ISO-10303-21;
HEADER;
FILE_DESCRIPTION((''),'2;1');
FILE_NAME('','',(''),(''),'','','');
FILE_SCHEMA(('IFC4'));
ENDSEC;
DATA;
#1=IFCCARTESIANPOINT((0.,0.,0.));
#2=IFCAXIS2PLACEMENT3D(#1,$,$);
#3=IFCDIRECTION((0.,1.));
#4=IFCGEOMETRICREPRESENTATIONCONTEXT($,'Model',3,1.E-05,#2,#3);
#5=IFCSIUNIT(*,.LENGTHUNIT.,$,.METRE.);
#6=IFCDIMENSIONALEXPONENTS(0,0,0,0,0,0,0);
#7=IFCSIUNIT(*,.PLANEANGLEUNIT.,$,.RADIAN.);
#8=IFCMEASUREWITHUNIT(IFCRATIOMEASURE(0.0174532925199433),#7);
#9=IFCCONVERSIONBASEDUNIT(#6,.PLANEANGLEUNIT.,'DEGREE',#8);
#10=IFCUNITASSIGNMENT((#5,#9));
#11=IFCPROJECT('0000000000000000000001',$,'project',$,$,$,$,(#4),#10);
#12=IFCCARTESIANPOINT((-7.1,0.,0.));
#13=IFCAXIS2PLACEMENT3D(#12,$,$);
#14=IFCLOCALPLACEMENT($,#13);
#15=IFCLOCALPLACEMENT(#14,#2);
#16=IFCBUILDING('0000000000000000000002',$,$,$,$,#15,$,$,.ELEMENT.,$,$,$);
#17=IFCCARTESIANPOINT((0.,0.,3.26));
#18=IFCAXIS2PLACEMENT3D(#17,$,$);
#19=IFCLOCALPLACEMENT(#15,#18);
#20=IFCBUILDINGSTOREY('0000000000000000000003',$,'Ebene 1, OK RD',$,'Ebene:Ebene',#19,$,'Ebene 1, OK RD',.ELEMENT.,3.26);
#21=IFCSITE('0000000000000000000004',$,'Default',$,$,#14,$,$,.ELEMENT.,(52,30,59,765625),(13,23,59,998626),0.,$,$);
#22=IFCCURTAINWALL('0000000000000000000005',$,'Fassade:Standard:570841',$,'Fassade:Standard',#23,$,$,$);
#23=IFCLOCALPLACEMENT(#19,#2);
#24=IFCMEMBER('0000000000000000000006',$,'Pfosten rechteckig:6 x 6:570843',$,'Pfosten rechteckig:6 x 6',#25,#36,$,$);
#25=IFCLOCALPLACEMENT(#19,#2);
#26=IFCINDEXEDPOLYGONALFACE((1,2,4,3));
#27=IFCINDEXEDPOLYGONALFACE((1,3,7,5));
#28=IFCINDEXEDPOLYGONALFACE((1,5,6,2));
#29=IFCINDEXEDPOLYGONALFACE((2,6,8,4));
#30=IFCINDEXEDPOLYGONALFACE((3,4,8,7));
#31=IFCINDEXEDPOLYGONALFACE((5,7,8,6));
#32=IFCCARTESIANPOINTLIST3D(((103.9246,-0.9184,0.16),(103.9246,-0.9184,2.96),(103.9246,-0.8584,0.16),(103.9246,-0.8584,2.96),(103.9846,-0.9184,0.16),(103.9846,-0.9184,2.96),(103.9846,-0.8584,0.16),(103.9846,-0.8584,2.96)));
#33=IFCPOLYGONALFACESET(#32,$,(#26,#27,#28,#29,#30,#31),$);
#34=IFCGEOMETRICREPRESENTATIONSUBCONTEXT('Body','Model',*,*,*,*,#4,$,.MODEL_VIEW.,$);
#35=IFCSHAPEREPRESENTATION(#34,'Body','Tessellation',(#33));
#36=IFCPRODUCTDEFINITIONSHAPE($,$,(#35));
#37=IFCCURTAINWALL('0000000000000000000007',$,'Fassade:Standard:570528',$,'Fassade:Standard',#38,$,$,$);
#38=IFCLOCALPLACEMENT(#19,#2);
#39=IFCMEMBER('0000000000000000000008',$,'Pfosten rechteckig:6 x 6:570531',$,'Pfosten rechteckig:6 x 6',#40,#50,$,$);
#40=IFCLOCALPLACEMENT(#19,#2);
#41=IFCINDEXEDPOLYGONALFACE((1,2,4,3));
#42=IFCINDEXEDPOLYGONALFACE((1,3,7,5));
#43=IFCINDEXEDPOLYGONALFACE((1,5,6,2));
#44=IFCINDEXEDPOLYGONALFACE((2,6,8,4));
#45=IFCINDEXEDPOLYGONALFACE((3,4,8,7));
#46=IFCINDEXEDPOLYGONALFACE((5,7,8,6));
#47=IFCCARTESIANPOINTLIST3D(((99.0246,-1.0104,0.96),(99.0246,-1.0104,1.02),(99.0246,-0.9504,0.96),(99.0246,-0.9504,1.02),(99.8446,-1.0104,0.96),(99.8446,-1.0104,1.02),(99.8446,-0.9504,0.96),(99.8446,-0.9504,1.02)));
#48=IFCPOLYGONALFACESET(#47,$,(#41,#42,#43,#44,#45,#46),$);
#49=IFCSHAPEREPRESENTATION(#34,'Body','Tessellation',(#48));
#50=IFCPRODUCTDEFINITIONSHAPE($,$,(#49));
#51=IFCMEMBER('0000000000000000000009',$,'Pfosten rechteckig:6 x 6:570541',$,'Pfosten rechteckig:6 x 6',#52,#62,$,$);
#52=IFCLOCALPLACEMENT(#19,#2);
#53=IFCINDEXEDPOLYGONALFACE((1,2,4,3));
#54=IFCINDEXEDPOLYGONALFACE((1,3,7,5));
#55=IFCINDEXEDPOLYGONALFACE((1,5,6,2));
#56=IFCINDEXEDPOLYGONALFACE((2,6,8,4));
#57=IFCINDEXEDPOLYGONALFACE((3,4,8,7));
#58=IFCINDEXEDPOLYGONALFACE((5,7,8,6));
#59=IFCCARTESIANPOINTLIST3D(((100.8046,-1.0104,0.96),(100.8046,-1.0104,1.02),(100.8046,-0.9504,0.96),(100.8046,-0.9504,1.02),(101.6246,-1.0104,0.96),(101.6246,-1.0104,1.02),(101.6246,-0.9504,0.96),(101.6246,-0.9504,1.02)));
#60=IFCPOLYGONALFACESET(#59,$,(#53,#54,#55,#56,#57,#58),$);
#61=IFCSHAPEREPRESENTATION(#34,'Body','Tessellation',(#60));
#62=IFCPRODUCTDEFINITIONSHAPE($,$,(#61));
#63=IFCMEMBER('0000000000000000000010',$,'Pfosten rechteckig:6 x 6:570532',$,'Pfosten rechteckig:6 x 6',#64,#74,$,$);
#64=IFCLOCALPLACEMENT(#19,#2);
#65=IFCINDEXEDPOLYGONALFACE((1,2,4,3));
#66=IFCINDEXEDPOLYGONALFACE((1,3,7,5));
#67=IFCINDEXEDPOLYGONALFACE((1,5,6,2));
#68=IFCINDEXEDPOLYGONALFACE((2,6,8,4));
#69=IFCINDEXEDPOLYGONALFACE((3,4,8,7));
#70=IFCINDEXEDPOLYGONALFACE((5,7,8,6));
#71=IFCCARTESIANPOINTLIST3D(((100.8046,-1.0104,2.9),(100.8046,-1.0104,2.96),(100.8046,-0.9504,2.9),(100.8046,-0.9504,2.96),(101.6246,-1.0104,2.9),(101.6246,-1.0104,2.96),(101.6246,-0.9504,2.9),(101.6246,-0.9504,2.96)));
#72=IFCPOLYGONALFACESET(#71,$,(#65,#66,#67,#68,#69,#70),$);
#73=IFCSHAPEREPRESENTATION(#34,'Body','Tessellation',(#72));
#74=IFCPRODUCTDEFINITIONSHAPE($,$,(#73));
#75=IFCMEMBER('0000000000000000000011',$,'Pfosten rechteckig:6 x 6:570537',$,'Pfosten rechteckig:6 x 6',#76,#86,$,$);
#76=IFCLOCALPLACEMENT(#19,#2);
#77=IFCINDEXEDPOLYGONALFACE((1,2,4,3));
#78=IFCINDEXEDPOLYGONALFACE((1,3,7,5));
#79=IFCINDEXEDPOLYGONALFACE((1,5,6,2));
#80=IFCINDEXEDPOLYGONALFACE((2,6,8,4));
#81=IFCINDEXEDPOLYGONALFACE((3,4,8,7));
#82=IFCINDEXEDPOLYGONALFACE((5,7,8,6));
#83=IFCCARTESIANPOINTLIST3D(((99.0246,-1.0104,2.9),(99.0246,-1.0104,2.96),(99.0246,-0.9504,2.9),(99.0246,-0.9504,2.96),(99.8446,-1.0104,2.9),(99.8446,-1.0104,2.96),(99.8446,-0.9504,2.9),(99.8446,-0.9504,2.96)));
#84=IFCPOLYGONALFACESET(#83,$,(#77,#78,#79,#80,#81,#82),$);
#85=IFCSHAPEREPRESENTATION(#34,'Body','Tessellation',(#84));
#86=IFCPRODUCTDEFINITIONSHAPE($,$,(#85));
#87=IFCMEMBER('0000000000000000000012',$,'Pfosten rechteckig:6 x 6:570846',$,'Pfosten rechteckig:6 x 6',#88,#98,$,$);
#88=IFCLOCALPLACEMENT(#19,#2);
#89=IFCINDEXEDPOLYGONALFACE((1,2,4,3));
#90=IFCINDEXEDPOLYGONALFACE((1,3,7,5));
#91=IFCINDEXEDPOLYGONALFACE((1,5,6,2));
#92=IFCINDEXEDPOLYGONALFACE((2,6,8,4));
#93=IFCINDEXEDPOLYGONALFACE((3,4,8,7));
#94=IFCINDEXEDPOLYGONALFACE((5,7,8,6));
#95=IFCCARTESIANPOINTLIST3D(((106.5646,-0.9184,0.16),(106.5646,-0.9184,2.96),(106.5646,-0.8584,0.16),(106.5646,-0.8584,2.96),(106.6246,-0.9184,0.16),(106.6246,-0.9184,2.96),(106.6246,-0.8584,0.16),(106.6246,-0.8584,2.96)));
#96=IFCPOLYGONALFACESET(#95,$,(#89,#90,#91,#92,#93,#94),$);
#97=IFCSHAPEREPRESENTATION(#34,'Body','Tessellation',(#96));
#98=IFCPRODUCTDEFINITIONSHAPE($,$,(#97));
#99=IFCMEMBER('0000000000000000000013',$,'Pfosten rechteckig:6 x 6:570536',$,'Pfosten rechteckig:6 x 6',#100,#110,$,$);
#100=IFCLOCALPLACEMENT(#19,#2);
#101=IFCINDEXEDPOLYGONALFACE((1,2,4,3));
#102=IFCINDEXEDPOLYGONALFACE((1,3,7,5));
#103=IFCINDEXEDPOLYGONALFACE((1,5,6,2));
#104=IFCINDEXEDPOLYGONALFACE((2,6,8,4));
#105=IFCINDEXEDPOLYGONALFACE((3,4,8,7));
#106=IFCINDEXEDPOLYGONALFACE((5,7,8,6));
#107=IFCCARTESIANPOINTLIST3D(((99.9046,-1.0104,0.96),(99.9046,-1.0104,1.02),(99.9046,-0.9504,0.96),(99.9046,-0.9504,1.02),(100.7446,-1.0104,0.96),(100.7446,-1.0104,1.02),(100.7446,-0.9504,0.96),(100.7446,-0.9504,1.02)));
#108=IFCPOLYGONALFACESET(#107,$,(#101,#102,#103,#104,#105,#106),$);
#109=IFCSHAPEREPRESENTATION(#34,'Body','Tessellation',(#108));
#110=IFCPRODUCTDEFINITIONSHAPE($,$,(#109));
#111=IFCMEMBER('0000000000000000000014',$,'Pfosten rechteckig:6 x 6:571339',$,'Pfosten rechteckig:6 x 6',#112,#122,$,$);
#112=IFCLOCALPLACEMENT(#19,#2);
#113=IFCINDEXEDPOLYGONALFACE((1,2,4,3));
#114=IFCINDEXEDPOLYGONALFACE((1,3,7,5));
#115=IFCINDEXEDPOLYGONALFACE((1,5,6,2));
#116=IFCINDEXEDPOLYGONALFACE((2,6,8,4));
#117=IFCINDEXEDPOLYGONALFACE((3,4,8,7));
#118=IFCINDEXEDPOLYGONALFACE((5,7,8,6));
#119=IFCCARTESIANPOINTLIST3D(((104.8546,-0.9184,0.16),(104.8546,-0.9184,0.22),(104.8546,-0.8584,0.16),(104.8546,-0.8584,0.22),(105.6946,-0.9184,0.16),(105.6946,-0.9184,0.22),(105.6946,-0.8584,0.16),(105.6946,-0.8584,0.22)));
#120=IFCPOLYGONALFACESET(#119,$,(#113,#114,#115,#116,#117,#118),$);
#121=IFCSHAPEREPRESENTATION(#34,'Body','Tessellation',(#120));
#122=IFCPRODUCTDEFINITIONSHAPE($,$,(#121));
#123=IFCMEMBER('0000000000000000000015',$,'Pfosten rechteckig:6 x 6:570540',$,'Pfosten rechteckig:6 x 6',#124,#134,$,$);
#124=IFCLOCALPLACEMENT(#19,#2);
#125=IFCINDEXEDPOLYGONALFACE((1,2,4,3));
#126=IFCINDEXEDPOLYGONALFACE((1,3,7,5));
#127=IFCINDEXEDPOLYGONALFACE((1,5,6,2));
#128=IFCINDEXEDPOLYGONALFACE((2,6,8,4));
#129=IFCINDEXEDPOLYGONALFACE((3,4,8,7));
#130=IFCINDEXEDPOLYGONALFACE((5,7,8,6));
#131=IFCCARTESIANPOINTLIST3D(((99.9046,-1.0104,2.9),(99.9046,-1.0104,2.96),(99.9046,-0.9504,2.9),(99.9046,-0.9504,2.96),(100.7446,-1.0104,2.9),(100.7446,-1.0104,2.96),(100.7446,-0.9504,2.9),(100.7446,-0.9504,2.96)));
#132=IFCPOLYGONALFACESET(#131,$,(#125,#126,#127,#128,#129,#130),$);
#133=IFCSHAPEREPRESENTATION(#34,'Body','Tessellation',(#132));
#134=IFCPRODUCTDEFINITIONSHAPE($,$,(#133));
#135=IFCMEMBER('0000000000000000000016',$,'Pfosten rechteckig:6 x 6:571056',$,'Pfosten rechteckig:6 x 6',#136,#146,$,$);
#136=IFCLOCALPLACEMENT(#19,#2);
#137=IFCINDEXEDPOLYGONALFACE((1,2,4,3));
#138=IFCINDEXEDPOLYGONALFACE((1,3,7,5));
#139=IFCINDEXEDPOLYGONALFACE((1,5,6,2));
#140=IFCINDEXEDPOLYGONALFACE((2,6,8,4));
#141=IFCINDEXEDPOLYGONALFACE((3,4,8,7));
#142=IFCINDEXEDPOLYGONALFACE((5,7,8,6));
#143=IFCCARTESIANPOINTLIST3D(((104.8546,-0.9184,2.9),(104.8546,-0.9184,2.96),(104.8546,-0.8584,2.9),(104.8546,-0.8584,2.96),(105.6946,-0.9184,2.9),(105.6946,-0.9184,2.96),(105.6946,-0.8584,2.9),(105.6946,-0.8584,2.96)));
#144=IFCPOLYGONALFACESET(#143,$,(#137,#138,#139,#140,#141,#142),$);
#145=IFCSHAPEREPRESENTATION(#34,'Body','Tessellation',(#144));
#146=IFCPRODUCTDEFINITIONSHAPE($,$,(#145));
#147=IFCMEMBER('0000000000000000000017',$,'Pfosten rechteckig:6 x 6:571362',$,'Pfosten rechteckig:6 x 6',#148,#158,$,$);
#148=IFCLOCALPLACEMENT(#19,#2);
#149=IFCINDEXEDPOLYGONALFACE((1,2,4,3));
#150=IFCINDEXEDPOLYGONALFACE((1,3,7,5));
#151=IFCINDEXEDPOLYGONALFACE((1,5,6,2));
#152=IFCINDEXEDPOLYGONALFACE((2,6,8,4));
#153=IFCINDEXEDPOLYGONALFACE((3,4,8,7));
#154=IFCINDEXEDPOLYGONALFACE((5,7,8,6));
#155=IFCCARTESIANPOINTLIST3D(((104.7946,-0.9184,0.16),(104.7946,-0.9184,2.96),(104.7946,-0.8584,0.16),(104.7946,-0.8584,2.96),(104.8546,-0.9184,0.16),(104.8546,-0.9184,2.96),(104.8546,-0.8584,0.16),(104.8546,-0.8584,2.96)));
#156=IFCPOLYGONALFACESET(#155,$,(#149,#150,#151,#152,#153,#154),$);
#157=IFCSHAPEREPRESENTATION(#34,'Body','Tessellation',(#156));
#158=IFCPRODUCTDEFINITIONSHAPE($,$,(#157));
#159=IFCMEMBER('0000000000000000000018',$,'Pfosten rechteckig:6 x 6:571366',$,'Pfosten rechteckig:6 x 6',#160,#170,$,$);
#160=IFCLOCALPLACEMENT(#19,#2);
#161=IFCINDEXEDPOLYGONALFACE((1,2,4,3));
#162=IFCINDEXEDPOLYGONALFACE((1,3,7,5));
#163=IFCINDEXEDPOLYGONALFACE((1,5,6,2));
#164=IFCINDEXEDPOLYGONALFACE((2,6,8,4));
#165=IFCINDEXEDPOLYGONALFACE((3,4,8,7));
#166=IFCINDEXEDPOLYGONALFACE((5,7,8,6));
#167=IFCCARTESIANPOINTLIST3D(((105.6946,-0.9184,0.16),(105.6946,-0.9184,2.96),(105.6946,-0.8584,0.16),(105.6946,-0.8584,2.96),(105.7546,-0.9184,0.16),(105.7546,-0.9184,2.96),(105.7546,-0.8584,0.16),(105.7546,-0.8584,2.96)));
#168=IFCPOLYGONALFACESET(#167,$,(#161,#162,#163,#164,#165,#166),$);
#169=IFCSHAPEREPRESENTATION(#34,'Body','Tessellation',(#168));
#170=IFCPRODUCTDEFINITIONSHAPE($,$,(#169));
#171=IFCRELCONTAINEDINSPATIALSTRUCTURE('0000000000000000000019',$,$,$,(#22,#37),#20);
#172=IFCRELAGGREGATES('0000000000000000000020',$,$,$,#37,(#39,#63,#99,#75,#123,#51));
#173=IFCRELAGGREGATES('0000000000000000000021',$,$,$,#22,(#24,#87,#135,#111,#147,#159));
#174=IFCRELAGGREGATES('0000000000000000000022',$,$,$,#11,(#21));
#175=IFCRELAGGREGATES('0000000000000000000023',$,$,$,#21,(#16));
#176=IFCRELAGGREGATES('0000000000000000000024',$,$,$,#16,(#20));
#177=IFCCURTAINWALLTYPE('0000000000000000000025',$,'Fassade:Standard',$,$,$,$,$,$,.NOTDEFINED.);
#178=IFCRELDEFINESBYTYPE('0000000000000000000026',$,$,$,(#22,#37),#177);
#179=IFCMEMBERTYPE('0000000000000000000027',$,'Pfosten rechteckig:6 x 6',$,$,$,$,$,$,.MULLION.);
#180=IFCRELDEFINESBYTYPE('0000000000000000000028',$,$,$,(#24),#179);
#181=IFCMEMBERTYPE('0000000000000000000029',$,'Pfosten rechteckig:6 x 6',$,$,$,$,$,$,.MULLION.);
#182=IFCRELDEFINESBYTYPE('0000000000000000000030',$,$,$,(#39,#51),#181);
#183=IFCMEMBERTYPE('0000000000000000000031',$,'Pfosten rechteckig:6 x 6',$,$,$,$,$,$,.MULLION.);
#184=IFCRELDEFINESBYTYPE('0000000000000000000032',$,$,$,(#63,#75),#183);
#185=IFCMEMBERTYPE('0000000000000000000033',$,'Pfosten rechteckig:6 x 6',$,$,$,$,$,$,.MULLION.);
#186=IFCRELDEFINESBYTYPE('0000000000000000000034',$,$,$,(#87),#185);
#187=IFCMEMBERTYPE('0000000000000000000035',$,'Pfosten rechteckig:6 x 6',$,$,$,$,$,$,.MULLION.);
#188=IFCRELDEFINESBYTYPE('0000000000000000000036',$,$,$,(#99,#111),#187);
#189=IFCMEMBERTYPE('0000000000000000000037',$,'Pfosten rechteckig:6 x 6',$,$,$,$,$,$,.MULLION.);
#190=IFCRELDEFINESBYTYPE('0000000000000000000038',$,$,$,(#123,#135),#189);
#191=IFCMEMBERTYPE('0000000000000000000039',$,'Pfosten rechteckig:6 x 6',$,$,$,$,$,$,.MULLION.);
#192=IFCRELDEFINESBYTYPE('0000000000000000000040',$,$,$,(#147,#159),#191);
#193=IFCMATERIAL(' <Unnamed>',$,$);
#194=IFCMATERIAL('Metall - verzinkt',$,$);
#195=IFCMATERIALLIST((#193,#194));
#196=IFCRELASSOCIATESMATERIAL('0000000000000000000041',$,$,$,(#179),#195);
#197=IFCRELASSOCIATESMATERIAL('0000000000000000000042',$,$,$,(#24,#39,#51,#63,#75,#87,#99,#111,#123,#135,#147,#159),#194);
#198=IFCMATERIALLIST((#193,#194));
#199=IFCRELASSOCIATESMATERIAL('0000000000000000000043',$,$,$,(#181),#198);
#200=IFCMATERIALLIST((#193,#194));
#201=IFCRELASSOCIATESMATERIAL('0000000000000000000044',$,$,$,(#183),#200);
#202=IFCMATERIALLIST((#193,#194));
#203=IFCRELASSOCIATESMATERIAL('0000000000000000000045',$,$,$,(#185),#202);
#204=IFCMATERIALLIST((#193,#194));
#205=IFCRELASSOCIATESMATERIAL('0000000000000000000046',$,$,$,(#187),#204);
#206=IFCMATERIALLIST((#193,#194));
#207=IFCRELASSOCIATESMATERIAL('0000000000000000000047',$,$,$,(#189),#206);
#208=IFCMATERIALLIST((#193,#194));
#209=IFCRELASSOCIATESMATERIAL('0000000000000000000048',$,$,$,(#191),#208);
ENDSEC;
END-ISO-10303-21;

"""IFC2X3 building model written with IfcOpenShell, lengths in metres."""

from ifc_helpers import new_model, entity, si_unit, converted_unit, direction, frame, origin, origin_2d_with_axis, place, context, subcontext, project, spatial, rectangle, extrude, source, transform, mapped, material, material_list, type_object, type_shapes, element, aggregate, save


model = new_model("IFC2X3")

# Units and contexts
model_context = context("Model", 3, precision=1e-05, world=origin(), true_north=direction((0.0, 1.0)))
body_context = subcontext(model_context, "Body", "Model", "MODEL_VIEW")
ifc_project = project(units=[si_unit("LENGTHUNIT", "METRE"), converted_unit("PLANEANGLEUNIT", "DEGREE", entity("IfcRatioMeasure", 0.0174532925199433), si_unit("PLANEANGLEUNIT", "RADIAN"), dimensions=[0, 0, 0, 0, 0, 0, 0])], contexts=[model_context])

# Site, building, storey
site_placement = place(None, frame((-7.1, 0.0, 0.0)))
site = spatial("IfcSite", under=ifc_project, at=site_placement, Name="Default", CompositionType="ELEMENT", RefLatitude=(52, 30, 59, 765625), RefLongitude=(13, 23, 59, 998626), RefElevation=0.0)
building_placement = place(site_placement, origin())
building = spatial("IfcBuilding", under=site, at=building_placement, CompositionType="ELEMENT")
storey_placement = place(building_placement, frame((0.0, 0.0, 3.26)))
storey = spatial("IfcBuildingStorey", under=building, at=storey_placement, Name="Ebene 1, OK RD", ObjectType="Ebene:Ebene", LongName="Ebene 1, OK RD", CompositionType="ELEMENT", Elevation=3.26)

# Curtain wall, member
curtain_wall_type = type_object("IfcCurtainWallType", Name="Fassade:Standard", PredefinedType="NOTDEFINED")
curtain_wall_1_placement = place(storey_placement, frame((0.0, 0.0, -3.26)))
curtain_wall_1 = element("IfcCurtainWall", 1, at=curtain_wall_1_placement, inside=storey, type_object=curtain_wall_type, Name="Fassade:Standard:570841", ObjectType="Fassade:Standard")
ifc_material_1 = material(Name="Metall - verzinkt")
ifc_material_2 = material(Name=" <Unnamed>")
ifc_material_list_1 = material_list([ifc_material_2, ifc_material_1])
member_type_1 = type_object("IfcMemberType", Name="Pfosten rechteckig:6 x 6", PredefinedType="MULLION", material=ifc_material_list_1)
shared_shape_1 = source(origin(), body_context, "Body", "SweptSolid", [
    extrude(rectangle(XDim=0.06, YDim=0.06, at=origin_2d_with_axis()), frame((-0.03, 0.0, -2.8), z_axis=(0.0, 0.0, 1.0), x_axis=(0.0, -1.0, 0.0)), (0.0, 0.0, 1.0), 2.8),
])
type_shapes(member_type_1, [shared_shape_1])
member_1_placement = place(storey_placement, frame((103.9246, -0.8884, 2.96), z_axis=(0.0, 0.0, 1.0), x_axis=(-1.0, 0.0, 0.0)))
member_1 = element("IfcMember", 2, at=member_1_placement, type_object=member_type_1, material=ifc_material_1, Name="Pfosten rechteckig:6 x 6:570843", ObjectType="Pfosten rechteckig:6 x 6", context=body_context, shape_type="MappedRepresentation", body=[
    mapped(shared_shape_1, transform((0.0, 0.0, 0.0), scale=1.0)),
])

# Curtain wall, members
curtain_wall_2_placement = place(storey_placement, frame((0.0, 0.0, -3.26)))
curtain_wall_2 = element("IfcCurtainWall", 3, at=curtain_wall_2_placement, inside=storey, type_object=curtain_wall_type, Name="Fassade:Standard:570528", ObjectType="Fassade:Standard")
ifc_material_list_2 = material_list([ifc_material_2, ifc_material_1])
member_type_2 = type_object("IfcMemberType", Name="Pfosten rechteckig:6 x 6", PredefinedType="MULLION", material=ifc_material_list_2)
shared_shape_2 = source(origin(), body_context, "Body", "SweptSolid", [
    extrude(rectangle(XDim=0.06, YDim=0.06, at=origin_2d_with_axis()), frame((-0.03, 0.0, -0.82), z_axis=(0.0, 0.0, 1.0), x_axis=(0.0, -1.0, 0.0)), (0.0, 0.0, 1.0), 0.82),
])
type_shapes(member_type_2, [shared_shape_2])
member_2_placement = place(storey_placement, frame((99.0246, -0.9804, 0.96), z_axis=(-1.0, 0.0, 0.0), x_axis=(0.0, 0.0, -1.0)))
member_2 = element("IfcMember", 4, at=member_2_placement, type_object=member_type_2, material=ifc_material_1, Name="Pfosten rechteckig:6 x 6:570531", ObjectType="Pfosten rechteckig:6 x 6", context=body_context, shape_type="MappedRepresentation", body=[
    mapped(shared_shape_2, transform((0.0, 0.0, 0.0), scale=1.0)),
])
member_3_placement = place(storey_placement, frame((100.8046, -0.9804, 0.96), z_axis=(-1.0, 0.0, 0.0), x_axis=(0.0, 0.0, -1.0)))
member_3 = element("IfcMember", 5, at=member_3_placement, type_object=member_type_2, material=ifc_material_1, Name="Pfosten rechteckig:6 x 6:570541", ObjectType="Pfosten rechteckig:6 x 6", context=body_context, shape_type="MappedRepresentation", body=[
    mapped(shared_shape_2, transform((0.0, 0.0, 0.0), scale=1.0)),
])
ifc_material_list_3 = material_list([ifc_material_2, ifc_material_1])
member_type_3 = type_object("IfcMemberType", Name="Pfosten rechteckig:6 x 6", PredefinedType="MULLION", material=ifc_material_list_3)
shared_shape_3 = source(origin(), body_context, "Body", "SweptSolid", [
    extrude(rectangle(XDim=0.06, YDim=0.06, at=origin_2d_with_axis()), frame((-0.03, 0.0, -0.82), z_axis=(0.0, 0.0, 1.0), x_axis=(0.0, -1.0, 0.0)), (0.0, 0.0, 1.0), 0.82),
])
type_shapes(member_type_3, [shared_shape_3])
member_4_placement = place(storey_placement, frame((101.6246, -0.9804, 2.96), z_axis=(1.0, 0.0, 0.0), x_axis=(0.0, 0.0, 1.0)))
member_4 = element("IfcMember", 6, at=member_4_placement, type_object=member_type_3, material=ifc_material_1, Name="Pfosten rechteckig:6 x 6:570532", ObjectType="Pfosten rechteckig:6 x 6", context=body_context, shape_type="MappedRepresentation", body=[
    mapped(shared_shape_3, transform((0.0, 0.0, 0.0), scale=1.0)),
])
member_5_placement = place(storey_placement, frame((99.8446, -0.9804, 2.96), z_axis=(1.0, 0.0, 0.0), x_axis=(0.0, 0.0, 1.0)))
member_5 = element("IfcMember", 7, at=member_5_placement, type_object=member_type_3, material=ifc_material_1, Name="Pfosten rechteckig:6 x 6:570537", ObjectType="Pfosten rechteckig:6 x 6", context=body_context, shape_type="MappedRepresentation", body=[
    mapped(shared_shape_3, transform((0.0, 0.0, 0.0), scale=1.0)),
])

# Members
ifc_material_list_4 = material_list([ifc_material_2, ifc_material_1])
member_type_4 = type_object("IfcMemberType", Name="Pfosten rechteckig:6 x 6", PredefinedType="MULLION", material=ifc_material_list_4)
shared_shape_4 = source(origin(), body_context, "Body", "SweptSolid", [
    extrude(rectangle(XDim=0.06, YDim=0.06, at=origin_2d_with_axis()), frame((-0.03, 0.0, -2.8), z_axis=(0.0, 0.0, 1.0), x_axis=(0.0, -1.0, 0.0)), (0.0, 0.0, 1.0), 2.8),
])
type_shapes(member_type_4, [shared_shape_4])
member_6_placement = place(storey_placement, frame((106.6246, -0.8884, 0.16), z_axis=(0.0, 0.0, -1.0), x_axis=(1.0, 0.0, 0.0)))
member_6 = element("IfcMember", 8, at=member_6_placement, type_object=member_type_4, material=ifc_material_1, Name="Pfosten rechteckig:6 x 6:570846", ObjectType="Pfosten rechteckig:6 x 6", context=body_context, shape_type="MappedRepresentation", body=[
    mapped(shared_shape_4, transform((0.0, 0.0, 0.0), scale=1.0)),
])
ifc_material_list_5 = material_list([ifc_material_2, ifc_material_1])
member_type_5 = type_object("IfcMemberType", Name="Pfosten rechteckig:6 x 6", PredefinedType="MULLION", material=ifc_material_list_5)
shared_shape_5 = source(origin(), body_context, "Body", "SweptSolid", [
    extrude(rectangle(XDim=0.06, YDim=0.06, at=origin_2d_with_axis()), frame((-0.03, 0.0, -0.84), z_axis=(0.0, 0.0, 1.0), x_axis=(0.0, -1.0, 0.0)), (0.0, 0.0, 1.0), 0.84),
])
type_shapes(member_type_5, [shared_shape_5])
member_7_placement = place(storey_placement, frame((99.9046, -0.9804, 0.96), z_axis=(-1.0, 0.0, 0.0), x_axis=(0.0, 0.0, -1.0)))
member_7 = element("IfcMember", 9, at=member_7_placement, type_object=member_type_5, material=ifc_material_1, Name="Pfosten rechteckig:6 x 6:570536", ObjectType="Pfosten rechteckig:6 x 6", context=body_context, shape_type="MappedRepresentation", body=[
    mapped(shared_shape_5, transform((0.0, 0.0, 0.0), scale=1.0)),
])
member_8_placement = place(storey_placement, frame((104.8546, -0.8884, 0.16), z_axis=(-1.0, 0.0, 0.0), x_axis=(0.0, 0.0, -1.0)))
member_8 = element("IfcMember", 10, at=member_8_placement, type_object=member_type_5, material=ifc_material_1, Name="Pfosten rechteckig:6 x 6:571339", ObjectType="Pfosten rechteckig:6 x 6", context=body_context, shape_type="MappedRepresentation", body=[
    mapped(shared_shape_5, transform((0.0, 0.0, 0.0), scale=1.0)),
])
ifc_material_list_6 = material_list([ifc_material_2, ifc_material_1])
member_type_6 = type_object("IfcMemberType", Name="Pfosten rechteckig:6 x 6", PredefinedType="MULLION", material=ifc_material_list_6)
shared_shape_6 = source(origin(), body_context, "Body", "SweptSolid", [
    extrude(rectangle(XDim=0.06, YDim=0.06, at=origin_2d_with_axis()), frame((-0.03, 0.0, -0.84), z_axis=(0.0, 0.0, 1.0), x_axis=(0.0, -1.0, 0.0)), (0.0, 0.0, 1.0), 0.84),
])
type_shapes(member_type_6, [shared_shape_6])
member_9_placement = place(storey_placement, frame((100.7446, -0.9804, 2.96), z_axis=(1.0, 0.0, 0.0), x_axis=(0.0, 0.0, 1.0)))
member_9 = element("IfcMember", 11, at=member_9_placement, type_object=member_type_6, material=ifc_material_1, Name="Pfosten rechteckig:6 x 6:570540", ObjectType="Pfosten rechteckig:6 x 6", context=body_context, shape_type="MappedRepresentation", body=[
    mapped(shared_shape_6, transform((0.0, 0.0, 0.0), scale=1.0)),
])
member_10_placement = place(storey_placement, frame((105.6946, -0.8884, 2.96), z_axis=(1.0, 0.0, 0.0), x_axis=(0.0, 0.0, 1.0)))
member_10 = element("IfcMember", 12, at=member_10_placement, type_object=member_type_6, material=ifc_material_1, Name="Pfosten rechteckig:6 x 6:571056", ObjectType="Pfosten rechteckig:6 x 6", context=body_context, shape_type="MappedRepresentation", body=[
    mapped(shared_shape_6, transform((0.0, 0.0, 0.0), scale=1.0)),
])
ifc_material_list_7 = material_list([ifc_material_2, ifc_material_1])
member_type_7 = type_object("IfcMemberType", Name="Pfosten rechteckig:6 x 6", PredefinedType="MULLION", material=ifc_material_list_7)
shared_shape_7 = source(origin(), body_context, "Body", "SweptSolid", [
    extrude(rectangle(XDim=0.06, YDim=0.06, at=origin_2d_with_axis()), frame((0.0, 0.0, -2.8), z_axis=(0.0, 0.0, 1.0), x_axis=(0.0, -1.0, 0.0)), (0.0, 0.0, 1.0), 2.8),
])
type_shapes(member_type_7, [shared_shape_7])
member_11_placement = place(storey_placement, frame((104.8246, -0.8884, 0.16), z_axis=(0.0, 0.0, -1.0), x_axis=(1.0, 0.0, 0.0)))
member_11 = element("IfcMember", 13, at=member_11_placement, type_object=member_type_7, material=ifc_material_1, Name="Pfosten rechteckig:6 x 6:571362", ObjectType="Pfosten rechteckig:6 x 6", context=body_context, shape_type="MappedRepresentation", body=[
    mapped(shared_shape_7, transform((0.0, 0.0, 0.0), scale=1.0)),
])
member_12_placement = place(storey_placement, frame((105.7246, -0.8884, 0.16), z_axis=(0.0, 0.0, -1.0), x_axis=(1.0, 0.0, 0.0)))
member_12 = element("IfcMember", 14, at=member_12_placement, type_object=member_type_7, material=ifc_material_1, Name="Pfosten rechteckig:6 x 6:571366", ObjectType="Pfosten rechteckig:6 x 6", context=body_context, shape_type="MappedRepresentation", body=[
    mapped(shared_shape_7, transform((0.0, 0.0, 0.0), scale=1.0)),
])

aggregate(curtain_wall_2, [member_2, member_4, member_7, member_5, member_9, member_3])
aggregate(curtain_wall_1, [member_1, member_6, member_10, member_8, member_11, member_12])

save(model, "model.ifc")
